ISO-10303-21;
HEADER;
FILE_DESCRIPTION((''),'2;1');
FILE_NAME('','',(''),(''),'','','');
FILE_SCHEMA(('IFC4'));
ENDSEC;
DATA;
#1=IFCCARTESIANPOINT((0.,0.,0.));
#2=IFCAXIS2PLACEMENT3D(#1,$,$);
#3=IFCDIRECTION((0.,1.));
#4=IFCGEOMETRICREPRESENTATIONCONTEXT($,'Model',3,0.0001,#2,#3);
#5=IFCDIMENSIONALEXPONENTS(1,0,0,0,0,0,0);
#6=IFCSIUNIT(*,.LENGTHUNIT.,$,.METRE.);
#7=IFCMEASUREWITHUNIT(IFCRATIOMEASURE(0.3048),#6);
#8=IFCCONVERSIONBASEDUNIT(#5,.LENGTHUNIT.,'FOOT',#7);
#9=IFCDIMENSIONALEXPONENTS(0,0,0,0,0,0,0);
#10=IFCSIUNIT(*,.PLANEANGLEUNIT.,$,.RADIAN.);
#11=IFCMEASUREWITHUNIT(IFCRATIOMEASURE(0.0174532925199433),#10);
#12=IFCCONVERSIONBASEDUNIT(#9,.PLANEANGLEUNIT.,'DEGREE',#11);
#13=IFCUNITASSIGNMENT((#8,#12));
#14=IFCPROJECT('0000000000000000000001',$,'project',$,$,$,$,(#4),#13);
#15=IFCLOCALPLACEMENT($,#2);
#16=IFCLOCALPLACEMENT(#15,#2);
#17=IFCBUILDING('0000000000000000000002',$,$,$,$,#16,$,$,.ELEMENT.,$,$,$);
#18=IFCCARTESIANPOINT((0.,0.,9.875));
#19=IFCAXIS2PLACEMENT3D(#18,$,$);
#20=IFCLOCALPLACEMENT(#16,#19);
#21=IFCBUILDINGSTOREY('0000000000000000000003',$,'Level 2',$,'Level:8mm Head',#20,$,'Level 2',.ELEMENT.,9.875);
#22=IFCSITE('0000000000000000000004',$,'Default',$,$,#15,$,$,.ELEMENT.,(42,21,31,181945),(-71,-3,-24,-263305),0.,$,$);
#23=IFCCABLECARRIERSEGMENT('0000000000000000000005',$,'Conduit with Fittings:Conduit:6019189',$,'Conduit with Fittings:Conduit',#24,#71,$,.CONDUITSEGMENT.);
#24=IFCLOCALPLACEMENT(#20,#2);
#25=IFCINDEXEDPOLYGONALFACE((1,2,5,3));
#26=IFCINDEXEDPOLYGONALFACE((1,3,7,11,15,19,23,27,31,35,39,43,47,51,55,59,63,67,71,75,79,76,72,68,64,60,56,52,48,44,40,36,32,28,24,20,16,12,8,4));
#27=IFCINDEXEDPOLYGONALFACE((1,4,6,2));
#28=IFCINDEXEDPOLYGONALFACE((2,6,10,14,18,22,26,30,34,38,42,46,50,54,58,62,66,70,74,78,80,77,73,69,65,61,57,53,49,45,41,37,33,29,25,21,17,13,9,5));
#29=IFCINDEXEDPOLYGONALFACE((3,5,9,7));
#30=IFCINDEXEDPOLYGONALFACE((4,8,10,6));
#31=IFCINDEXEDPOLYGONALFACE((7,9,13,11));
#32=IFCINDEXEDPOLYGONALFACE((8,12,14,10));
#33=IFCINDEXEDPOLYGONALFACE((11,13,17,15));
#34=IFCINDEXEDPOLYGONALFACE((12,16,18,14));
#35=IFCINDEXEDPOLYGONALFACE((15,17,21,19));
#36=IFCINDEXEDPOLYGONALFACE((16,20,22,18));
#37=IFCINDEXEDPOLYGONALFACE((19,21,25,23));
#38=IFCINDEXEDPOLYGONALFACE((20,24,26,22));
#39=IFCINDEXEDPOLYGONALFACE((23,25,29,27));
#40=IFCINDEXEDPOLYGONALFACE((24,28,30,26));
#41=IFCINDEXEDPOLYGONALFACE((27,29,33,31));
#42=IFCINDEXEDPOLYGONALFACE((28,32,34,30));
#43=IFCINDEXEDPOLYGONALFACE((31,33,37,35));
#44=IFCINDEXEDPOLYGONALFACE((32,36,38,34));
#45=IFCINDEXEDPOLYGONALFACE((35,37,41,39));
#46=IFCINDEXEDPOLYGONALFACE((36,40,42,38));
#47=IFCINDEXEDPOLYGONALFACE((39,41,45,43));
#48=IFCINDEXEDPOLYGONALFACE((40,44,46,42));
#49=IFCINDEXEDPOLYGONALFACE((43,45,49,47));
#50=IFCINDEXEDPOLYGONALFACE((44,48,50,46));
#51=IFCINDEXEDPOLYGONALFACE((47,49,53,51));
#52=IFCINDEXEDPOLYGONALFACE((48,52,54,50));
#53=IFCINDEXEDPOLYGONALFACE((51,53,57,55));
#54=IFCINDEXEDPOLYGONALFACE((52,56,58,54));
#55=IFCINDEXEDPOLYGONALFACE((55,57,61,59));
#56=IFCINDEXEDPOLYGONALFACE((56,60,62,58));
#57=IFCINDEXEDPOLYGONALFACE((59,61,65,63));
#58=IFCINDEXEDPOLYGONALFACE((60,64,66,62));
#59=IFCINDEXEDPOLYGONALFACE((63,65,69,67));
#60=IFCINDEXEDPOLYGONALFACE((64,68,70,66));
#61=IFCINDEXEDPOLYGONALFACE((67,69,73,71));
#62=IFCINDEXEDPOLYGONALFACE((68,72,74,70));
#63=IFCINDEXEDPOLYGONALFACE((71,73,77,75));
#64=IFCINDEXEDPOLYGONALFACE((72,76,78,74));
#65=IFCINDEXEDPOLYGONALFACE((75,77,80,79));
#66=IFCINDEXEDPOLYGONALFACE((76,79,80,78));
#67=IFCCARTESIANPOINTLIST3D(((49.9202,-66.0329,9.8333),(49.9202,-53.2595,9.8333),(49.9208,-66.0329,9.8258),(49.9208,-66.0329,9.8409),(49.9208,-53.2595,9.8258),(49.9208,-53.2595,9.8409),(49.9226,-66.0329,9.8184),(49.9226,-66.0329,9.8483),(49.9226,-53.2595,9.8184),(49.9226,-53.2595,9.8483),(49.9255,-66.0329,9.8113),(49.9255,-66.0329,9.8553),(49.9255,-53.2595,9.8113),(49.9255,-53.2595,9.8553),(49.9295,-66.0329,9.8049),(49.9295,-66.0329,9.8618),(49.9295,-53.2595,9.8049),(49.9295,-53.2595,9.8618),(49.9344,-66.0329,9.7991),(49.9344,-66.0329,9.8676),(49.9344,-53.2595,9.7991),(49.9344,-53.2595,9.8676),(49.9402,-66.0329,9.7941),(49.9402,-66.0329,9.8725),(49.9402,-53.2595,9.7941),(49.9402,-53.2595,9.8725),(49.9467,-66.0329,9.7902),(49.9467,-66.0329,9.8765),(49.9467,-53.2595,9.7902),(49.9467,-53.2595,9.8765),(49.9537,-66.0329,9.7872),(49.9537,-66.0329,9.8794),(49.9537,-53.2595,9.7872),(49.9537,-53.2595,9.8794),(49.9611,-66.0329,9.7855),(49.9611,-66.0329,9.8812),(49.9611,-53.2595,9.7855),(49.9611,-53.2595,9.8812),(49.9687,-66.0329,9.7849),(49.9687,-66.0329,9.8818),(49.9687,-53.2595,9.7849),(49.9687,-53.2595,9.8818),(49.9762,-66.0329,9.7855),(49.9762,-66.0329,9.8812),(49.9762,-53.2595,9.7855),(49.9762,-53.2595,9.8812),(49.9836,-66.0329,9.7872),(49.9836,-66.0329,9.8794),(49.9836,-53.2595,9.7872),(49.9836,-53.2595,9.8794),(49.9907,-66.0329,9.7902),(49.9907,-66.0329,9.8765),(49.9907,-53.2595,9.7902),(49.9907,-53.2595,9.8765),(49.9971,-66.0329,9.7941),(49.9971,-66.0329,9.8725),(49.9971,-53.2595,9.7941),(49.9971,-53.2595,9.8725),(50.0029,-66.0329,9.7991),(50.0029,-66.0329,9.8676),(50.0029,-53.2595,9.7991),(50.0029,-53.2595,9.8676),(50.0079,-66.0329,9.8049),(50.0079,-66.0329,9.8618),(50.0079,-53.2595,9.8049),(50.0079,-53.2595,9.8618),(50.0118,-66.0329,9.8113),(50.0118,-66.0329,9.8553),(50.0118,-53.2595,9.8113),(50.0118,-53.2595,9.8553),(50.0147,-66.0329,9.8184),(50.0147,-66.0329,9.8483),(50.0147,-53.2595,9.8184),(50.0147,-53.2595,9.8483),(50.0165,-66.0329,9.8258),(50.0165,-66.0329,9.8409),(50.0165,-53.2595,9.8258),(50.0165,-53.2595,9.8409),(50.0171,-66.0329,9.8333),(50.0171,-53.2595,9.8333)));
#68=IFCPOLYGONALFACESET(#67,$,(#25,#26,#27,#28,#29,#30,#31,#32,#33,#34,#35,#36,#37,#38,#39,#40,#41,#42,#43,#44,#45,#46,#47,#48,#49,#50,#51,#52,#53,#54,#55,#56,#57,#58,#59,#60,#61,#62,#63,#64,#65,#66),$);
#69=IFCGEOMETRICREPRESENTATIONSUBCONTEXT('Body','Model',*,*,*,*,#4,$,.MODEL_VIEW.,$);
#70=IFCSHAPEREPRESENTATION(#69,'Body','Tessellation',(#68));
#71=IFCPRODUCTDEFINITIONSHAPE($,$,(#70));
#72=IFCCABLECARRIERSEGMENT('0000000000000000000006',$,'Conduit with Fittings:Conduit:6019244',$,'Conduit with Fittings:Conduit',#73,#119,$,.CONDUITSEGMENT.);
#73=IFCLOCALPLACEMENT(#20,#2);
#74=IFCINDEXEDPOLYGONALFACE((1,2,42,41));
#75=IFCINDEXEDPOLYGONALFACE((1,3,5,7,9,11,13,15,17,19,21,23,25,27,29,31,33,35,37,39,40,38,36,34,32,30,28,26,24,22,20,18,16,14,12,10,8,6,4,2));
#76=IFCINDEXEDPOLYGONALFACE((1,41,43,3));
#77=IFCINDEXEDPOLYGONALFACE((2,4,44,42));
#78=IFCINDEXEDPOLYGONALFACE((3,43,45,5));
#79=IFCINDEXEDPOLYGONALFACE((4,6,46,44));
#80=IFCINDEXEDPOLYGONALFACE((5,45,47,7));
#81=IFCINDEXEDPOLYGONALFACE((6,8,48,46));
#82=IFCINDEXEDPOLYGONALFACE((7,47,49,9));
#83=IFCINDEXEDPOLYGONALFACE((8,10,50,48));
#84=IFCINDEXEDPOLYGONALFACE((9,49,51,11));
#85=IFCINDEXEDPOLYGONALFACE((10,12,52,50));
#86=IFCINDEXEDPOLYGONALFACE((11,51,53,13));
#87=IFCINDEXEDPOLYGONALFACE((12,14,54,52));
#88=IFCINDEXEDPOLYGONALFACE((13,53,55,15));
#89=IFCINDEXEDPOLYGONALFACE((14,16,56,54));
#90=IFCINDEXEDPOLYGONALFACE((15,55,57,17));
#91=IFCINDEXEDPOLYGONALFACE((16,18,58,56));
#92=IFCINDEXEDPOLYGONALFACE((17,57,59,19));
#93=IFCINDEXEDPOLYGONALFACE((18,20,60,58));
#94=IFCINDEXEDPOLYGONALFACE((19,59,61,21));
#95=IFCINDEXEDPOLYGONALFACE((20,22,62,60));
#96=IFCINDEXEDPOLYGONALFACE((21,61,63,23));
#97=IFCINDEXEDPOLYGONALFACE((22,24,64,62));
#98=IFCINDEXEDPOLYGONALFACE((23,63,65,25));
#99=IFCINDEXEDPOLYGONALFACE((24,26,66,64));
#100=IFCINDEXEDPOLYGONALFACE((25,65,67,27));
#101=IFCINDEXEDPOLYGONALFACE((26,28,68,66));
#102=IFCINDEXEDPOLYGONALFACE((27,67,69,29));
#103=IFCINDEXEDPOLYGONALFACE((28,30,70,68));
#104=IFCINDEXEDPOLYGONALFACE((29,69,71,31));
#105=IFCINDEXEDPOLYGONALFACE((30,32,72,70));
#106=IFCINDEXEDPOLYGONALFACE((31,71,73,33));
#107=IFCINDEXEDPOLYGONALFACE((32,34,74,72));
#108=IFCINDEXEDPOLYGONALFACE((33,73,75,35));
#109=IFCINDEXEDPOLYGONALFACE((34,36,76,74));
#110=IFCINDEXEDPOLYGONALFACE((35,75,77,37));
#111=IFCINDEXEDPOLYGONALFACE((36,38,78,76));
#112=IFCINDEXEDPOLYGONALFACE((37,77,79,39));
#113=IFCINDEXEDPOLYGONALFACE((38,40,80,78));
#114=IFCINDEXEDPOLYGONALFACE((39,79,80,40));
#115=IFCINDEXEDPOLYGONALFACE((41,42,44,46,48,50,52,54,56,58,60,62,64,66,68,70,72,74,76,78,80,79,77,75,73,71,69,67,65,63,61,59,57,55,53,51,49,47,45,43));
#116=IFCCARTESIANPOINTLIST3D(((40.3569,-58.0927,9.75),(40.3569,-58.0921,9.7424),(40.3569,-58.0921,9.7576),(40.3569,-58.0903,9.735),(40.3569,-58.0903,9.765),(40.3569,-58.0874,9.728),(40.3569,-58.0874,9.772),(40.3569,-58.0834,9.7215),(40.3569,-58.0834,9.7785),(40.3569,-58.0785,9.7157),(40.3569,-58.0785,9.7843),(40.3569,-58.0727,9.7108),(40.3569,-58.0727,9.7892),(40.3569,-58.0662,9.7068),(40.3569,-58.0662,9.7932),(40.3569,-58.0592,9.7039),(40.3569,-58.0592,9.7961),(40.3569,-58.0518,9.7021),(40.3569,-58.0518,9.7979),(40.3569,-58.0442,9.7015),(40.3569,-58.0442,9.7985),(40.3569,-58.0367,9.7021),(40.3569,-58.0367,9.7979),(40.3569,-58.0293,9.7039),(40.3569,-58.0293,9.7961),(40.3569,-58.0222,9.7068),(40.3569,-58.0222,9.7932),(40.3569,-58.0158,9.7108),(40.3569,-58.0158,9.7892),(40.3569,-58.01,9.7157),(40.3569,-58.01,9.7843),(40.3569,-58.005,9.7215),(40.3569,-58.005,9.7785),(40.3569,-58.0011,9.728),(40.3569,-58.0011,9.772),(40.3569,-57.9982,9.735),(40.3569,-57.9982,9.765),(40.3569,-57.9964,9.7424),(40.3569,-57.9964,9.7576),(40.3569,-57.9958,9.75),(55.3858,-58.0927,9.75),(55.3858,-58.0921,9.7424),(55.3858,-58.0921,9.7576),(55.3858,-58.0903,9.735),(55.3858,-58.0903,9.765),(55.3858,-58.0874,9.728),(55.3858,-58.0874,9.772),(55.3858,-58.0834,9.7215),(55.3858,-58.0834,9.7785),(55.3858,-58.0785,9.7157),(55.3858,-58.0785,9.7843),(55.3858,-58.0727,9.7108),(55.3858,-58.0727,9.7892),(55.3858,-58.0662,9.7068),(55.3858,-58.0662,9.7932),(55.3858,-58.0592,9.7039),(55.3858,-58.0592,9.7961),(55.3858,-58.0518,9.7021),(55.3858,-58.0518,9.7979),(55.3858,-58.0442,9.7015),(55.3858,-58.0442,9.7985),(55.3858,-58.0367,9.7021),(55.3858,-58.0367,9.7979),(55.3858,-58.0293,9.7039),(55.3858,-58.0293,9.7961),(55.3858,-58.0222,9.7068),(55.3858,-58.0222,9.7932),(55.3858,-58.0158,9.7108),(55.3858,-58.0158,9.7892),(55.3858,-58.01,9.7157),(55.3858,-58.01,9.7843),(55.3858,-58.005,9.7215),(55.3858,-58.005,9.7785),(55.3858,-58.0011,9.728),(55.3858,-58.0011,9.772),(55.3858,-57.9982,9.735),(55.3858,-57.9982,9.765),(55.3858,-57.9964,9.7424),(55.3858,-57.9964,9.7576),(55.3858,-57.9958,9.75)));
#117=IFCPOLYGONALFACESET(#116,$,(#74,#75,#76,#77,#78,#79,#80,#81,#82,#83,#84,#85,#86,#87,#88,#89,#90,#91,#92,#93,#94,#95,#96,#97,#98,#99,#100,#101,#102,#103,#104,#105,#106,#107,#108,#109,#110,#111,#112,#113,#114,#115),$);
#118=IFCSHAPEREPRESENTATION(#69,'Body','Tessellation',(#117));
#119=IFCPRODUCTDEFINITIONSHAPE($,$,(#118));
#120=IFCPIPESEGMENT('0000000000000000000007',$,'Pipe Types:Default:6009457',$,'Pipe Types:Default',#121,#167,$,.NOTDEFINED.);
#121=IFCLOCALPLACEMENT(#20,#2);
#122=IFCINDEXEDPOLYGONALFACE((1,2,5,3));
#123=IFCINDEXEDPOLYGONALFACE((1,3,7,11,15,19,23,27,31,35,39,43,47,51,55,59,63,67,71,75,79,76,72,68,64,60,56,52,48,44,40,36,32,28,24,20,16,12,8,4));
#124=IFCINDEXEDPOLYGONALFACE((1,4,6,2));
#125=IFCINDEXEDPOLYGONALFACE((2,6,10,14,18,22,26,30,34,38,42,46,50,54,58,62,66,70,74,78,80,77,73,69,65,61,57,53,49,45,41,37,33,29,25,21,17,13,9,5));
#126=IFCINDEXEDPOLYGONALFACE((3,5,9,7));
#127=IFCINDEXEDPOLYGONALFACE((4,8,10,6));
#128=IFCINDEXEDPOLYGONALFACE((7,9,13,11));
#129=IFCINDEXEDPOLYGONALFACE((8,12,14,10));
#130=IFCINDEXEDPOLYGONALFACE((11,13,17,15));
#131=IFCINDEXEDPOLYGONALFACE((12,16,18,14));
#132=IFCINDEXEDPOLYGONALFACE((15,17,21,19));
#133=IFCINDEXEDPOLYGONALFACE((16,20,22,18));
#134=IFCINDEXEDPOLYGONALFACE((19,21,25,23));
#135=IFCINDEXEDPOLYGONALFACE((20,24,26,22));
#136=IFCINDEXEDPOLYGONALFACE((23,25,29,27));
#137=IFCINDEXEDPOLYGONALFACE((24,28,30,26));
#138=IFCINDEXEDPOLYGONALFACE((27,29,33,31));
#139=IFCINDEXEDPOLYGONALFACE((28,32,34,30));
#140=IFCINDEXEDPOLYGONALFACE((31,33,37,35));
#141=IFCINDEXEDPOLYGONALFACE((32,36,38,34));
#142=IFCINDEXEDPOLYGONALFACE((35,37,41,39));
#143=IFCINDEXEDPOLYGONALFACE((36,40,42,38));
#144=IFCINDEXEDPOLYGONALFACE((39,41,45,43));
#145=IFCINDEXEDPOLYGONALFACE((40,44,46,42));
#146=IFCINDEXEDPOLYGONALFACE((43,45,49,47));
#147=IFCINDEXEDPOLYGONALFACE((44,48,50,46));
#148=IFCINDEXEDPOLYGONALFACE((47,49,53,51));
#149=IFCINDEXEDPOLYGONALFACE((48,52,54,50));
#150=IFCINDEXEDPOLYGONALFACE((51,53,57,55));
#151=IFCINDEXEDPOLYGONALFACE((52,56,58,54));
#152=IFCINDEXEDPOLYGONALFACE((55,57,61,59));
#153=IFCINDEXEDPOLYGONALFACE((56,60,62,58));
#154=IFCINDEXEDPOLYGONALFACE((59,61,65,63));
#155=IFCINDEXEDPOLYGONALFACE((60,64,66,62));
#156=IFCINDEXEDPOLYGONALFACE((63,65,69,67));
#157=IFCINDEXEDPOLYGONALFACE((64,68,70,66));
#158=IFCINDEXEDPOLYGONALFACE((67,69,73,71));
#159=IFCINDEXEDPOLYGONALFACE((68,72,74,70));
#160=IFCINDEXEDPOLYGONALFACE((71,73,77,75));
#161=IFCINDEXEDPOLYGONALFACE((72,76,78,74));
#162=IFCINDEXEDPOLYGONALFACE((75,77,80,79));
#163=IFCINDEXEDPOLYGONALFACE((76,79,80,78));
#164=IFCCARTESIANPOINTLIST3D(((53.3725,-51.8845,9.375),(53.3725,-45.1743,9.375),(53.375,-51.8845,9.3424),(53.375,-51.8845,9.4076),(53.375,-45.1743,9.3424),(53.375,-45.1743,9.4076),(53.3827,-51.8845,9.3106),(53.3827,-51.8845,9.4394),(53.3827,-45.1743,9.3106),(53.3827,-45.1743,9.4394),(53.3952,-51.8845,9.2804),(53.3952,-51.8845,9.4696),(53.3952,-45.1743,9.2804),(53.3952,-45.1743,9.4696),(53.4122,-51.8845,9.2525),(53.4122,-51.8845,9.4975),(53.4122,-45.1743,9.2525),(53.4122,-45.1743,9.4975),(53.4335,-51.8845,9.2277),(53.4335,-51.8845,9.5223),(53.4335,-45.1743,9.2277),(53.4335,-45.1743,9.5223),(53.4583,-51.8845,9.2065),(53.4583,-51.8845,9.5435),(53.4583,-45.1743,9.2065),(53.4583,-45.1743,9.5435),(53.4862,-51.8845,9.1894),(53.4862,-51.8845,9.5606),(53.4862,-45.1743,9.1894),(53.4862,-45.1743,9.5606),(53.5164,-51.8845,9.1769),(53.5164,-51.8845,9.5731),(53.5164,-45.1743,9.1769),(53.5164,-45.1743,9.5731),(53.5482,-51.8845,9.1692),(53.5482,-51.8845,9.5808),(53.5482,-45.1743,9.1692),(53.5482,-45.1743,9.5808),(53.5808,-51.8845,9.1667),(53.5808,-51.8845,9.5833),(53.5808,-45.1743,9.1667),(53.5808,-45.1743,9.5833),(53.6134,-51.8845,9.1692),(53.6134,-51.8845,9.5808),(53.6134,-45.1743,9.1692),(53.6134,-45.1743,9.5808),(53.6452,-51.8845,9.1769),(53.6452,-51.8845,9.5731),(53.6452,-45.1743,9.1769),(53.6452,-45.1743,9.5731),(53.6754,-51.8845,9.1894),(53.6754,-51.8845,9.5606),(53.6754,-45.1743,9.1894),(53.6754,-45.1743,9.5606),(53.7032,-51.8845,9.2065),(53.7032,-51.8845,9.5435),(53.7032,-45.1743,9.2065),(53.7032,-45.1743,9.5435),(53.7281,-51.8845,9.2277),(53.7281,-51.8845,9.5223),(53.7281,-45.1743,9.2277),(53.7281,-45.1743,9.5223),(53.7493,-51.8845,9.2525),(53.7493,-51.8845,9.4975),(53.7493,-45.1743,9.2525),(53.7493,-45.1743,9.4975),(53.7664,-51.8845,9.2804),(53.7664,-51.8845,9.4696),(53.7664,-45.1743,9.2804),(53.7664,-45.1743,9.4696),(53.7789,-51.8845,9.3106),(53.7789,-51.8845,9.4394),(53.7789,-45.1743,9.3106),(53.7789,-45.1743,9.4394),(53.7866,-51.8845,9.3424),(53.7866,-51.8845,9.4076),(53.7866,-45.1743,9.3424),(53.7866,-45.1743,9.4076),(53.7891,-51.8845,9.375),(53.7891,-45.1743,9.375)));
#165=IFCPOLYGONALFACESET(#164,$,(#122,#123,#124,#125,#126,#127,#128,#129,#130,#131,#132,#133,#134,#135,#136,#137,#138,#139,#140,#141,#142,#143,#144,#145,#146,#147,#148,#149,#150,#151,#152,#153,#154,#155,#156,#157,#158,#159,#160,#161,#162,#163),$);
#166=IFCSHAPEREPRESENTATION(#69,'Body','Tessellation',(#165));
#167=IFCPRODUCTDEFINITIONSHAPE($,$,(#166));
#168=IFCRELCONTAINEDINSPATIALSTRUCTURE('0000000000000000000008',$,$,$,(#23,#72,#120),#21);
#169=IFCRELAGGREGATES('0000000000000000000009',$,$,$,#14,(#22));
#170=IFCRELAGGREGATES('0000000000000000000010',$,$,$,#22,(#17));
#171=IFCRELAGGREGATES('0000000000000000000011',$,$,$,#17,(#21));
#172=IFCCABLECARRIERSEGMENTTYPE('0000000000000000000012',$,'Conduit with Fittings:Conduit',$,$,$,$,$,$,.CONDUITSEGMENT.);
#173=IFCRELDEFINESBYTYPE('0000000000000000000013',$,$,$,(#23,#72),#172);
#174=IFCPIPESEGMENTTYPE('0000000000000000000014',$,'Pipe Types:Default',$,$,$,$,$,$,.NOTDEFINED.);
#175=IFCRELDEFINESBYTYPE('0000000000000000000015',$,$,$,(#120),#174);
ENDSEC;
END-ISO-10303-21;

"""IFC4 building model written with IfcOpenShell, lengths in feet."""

from ifc_helpers import new_model, entity, si_unit, converted_unit, direction, frame, origin, place, context, subcontext, project, spatial, indexed_curve, outline, extrude, type_object, element, save


model = new_model("IFC4")

# Units and contexts
model_context = context("Model", 3, precision=0.0001, world=origin(), true_north=direction((0.0, 1.0)))
body_context = subcontext(model_context, "Body", "Model", "MODEL_VIEW")
ifc_project = project(units=[converted_unit("LENGTHUNIT", "FOOT", entity("IfcRatioMeasure", 0.3048), si_unit("LENGTHUNIT", "METRE"), dimensions=[1, 0, 0, 0, 0, 0, 0]), converted_unit("PLANEANGLEUNIT", "DEGREE", entity("IfcRatioMeasure", 0.0174532925199433), si_unit("PLANEANGLEUNIT", "RADIAN"), dimensions=[0, 0, 0, 0, 0, 0, 0])], contexts=[model_context])

# Site, building, storey
site_placement = place(None, origin())
site = spatial("IfcSite", under=ifc_project, at=site_placement, Name="Default", CompositionType="ELEMENT", RefLatitude=(42, 21, 31, 181945), RefLongitude=(-71, -3, -24, -263305), RefElevation=0.0)
building_placement = place(site_placement, origin())
building = spatial("IfcBuilding", under=site, at=building_placement, CompositionType="ELEMENT")
storey_placement = place(building_placement, frame((0.0, 0.0, 9.875)))
storey = spatial("IfcBuildingStorey", under=building, at=storey_placement, Name="Level 2", ObjectType="Level:8mm Head", LongName="Level 2", CompositionType="ELEMENT", Elevation=9.875)

# Cable carrier segments
cable_carrier_segment_type = type_object("IfcCableCarrierSegmentType", Name="Conduit with Fittings:Conduit", PredefinedType="CONDUITSEGMENT")
cable_carrier_segment_1_placement = place(storey_placement, origin())
element("IfcCableCarrierSegment", 1, at=cable_carrier_segment_1_placement, inside=storey, type_object=cable_carrier_segment_type, Name="Conduit with Fittings:Conduit:6019189", ObjectType="Conduit with Fittings:Conduit", PredefinedType="CONDUITSEGMENT", context=body_context, shape_type="SweptSolid", body=[
    extrude(outline(indexed_curve([(0.0485, 0.0), (0.0479, 0.0076), (0.0461, 0.015), (0.0432, 0.022), (0.0392, 0.0285), (0.0343, 0.0343), (0.0285, 0.0392), (0.022, 0.0432), (0.015, 0.0461), (0.0076, 0.0479), (0.0, 0.0485), (-0.0076, 0.0479), (-0.015, 0.0461), (-0.022, 0.0432), (-0.0285, 0.0392), (-0.0343, 0.0343), (-0.0392, 0.0285), (-0.0432, 0.022), (-0.0461, 0.015), (-0.0479, 0.0076), (-0.0485, 0.0), (-0.0479, -0.0076), (-0.0461, -0.015), (-0.0432, -0.022), (-0.0392, -0.0285), (-0.0343, -0.0343), (-0.0285, -0.0392), (-0.022, -0.0432), (-0.015, -0.0461), (-0.0076, -0.0479), (0.0, -0.0485), (0.0076, -0.0479), (0.015, -0.0461), (0.022, -0.0432), (0.0285, -0.0392), (0.0343, -0.0343), (0.0392, -0.0285), (0.0432, -0.022), (0.0461, -0.015), (0.0479, -0.0076), (0.0485, 0.0)], self_intersect=False)), frame((49.9687, -66.0329, 9.8333), z_axis=(0.0, 1.0, 0.0), x_axis=(-1.0, 0.0, 0.0)), (0.0, 0.0, 1.0), 12.7735),
])
cable_carrier_segment_2_placement = place(storey_placement, origin())
element("IfcCableCarrierSegment", 2, at=cable_carrier_segment_2_placement, inside=storey, type_object=cable_carrier_segment_type, Name="Conduit with Fittings:Conduit:6019244", ObjectType="Conduit with Fittings:Conduit", PredefinedType="CONDUITSEGMENT", context=body_context, shape_type="SweptSolid", body=[
    extrude(outline(indexed_curve([(0.0485, 0.0), (0.0479, 0.0076), (0.0461, 0.015), (0.0432, 0.022), (0.0392, 0.0285), (0.0343, 0.0343), (0.0285, 0.0392), (0.022, 0.0432), (0.015, 0.0461), (0.0076, 0.0479), (0.0, 0.0485), (-0.0076, 0.0479), (-0.015, 0.0461), (-0.022, 0.0432), (-0.0285, 0.0392), (-0.0343, 0.0343), (-0.0392, 0.0285), (-0.0432, 0.022), (-0.0461, 0.015), (-0.0479, 0.0076), (-0.0485, 0.0), (-0.0479, -0.0076), (-0.0461, -0.015), (-0.0432, -0.022), (-0.0392, -0.0285), (-0.0343, -0.0343), (-0.0285, -0.0392), (-0.022, -0.0432), (-0.015, -0.0461), (-0.0076, -0.0479), (0.0, -0.0485), (0.0076, -0.0479), (0.015, -0.0461), (0.022, -0.0432), (0.0285, -0.0392), (0.0343, -0.0343), (0.0392, -0.0285), (0.0432, -0.022), (0.0461, -0.015), (0.0479, -0.0076), (0.0485, 0.0)], self_intersect=False)), frame((40.3569, -58.0442, 9.75), z_axis=(1.0, 0.0, 0.0), x_axis=(0.0, 1.0, 0.0)), (0.0, 0.0, 1.0), 15.0289),
])

# Pipe segment
pipe_segment_type = type_object("IfcPipeSegmentType", Name="Pipe Types:Default", PredefinedType="NOTDEFINED")
pipe_segment_1_placement = place(storey_placement, origin())
element("IfcPipeSegment", 3, at=pipe_segment_1_placement, inside=storey, type_object=pipe_segment_type, Name="Pipe Types:Default:6009457", ObjectType="Pipe Types:Default", PredefinedType="NOTDEFINED", context=body_context, shape_type="SweptSolid", body=[
    extrude(outline(indexed_curve([(0.2083, 0.0), (0.2058, 0.0326), (0.1981, 0.0644), (0.1856, 0.0946), (0.1685, 0.1225), (0.1473, 0.1473), (0.1225, 0.1685), (0.0946, 0.1856), (0.0644, 0.1981), (0.0326, 0.2058), (0.0, 0.2083), (-0.0326, 0.2058), (-0.0644, 0.1981), (-0.0946, 0.1856), (-0.1225, 0.1685), (-0.1473, 0.1473), (-0.1685, 0.1225), (-0.1856, 0.0946), (-0.1981, 0.0644), (-0.2058, 0.0326), (-0.2083, 0.0), (-0.2058, -0.0326), (-0.1981, -0.0644), (-0.1856, -0.0946), (-0.1685, -0.1225), (-0.1473, -0.1473), (-0.1225, -0.1685), (-0.0946, -0.1856), (-0.0644, -0.1981), (-0.0326, -0.2058), (0.0, -0.2083), (0.0326, -0.2058), (0.0644, -0.1981), (0.0946, -0.1856), (0.1225, -0.1685), (0.1473, -0.1473), (0.1685, -0.1225), (0.1856, -0.0946), (0.1981, -0.0644), (0.2058, -0.0326), (0.2083, 0.0)], self_intersect=False)), frame((53.5808, -51.8845, 9.375), z_axis=(0.0, 1.0, 0.0), x_axis=(1.0, 0.0, 0.0)), (0.0, 0.0, 1.0), 6.7102),
])

save(model, "model.ifc")
